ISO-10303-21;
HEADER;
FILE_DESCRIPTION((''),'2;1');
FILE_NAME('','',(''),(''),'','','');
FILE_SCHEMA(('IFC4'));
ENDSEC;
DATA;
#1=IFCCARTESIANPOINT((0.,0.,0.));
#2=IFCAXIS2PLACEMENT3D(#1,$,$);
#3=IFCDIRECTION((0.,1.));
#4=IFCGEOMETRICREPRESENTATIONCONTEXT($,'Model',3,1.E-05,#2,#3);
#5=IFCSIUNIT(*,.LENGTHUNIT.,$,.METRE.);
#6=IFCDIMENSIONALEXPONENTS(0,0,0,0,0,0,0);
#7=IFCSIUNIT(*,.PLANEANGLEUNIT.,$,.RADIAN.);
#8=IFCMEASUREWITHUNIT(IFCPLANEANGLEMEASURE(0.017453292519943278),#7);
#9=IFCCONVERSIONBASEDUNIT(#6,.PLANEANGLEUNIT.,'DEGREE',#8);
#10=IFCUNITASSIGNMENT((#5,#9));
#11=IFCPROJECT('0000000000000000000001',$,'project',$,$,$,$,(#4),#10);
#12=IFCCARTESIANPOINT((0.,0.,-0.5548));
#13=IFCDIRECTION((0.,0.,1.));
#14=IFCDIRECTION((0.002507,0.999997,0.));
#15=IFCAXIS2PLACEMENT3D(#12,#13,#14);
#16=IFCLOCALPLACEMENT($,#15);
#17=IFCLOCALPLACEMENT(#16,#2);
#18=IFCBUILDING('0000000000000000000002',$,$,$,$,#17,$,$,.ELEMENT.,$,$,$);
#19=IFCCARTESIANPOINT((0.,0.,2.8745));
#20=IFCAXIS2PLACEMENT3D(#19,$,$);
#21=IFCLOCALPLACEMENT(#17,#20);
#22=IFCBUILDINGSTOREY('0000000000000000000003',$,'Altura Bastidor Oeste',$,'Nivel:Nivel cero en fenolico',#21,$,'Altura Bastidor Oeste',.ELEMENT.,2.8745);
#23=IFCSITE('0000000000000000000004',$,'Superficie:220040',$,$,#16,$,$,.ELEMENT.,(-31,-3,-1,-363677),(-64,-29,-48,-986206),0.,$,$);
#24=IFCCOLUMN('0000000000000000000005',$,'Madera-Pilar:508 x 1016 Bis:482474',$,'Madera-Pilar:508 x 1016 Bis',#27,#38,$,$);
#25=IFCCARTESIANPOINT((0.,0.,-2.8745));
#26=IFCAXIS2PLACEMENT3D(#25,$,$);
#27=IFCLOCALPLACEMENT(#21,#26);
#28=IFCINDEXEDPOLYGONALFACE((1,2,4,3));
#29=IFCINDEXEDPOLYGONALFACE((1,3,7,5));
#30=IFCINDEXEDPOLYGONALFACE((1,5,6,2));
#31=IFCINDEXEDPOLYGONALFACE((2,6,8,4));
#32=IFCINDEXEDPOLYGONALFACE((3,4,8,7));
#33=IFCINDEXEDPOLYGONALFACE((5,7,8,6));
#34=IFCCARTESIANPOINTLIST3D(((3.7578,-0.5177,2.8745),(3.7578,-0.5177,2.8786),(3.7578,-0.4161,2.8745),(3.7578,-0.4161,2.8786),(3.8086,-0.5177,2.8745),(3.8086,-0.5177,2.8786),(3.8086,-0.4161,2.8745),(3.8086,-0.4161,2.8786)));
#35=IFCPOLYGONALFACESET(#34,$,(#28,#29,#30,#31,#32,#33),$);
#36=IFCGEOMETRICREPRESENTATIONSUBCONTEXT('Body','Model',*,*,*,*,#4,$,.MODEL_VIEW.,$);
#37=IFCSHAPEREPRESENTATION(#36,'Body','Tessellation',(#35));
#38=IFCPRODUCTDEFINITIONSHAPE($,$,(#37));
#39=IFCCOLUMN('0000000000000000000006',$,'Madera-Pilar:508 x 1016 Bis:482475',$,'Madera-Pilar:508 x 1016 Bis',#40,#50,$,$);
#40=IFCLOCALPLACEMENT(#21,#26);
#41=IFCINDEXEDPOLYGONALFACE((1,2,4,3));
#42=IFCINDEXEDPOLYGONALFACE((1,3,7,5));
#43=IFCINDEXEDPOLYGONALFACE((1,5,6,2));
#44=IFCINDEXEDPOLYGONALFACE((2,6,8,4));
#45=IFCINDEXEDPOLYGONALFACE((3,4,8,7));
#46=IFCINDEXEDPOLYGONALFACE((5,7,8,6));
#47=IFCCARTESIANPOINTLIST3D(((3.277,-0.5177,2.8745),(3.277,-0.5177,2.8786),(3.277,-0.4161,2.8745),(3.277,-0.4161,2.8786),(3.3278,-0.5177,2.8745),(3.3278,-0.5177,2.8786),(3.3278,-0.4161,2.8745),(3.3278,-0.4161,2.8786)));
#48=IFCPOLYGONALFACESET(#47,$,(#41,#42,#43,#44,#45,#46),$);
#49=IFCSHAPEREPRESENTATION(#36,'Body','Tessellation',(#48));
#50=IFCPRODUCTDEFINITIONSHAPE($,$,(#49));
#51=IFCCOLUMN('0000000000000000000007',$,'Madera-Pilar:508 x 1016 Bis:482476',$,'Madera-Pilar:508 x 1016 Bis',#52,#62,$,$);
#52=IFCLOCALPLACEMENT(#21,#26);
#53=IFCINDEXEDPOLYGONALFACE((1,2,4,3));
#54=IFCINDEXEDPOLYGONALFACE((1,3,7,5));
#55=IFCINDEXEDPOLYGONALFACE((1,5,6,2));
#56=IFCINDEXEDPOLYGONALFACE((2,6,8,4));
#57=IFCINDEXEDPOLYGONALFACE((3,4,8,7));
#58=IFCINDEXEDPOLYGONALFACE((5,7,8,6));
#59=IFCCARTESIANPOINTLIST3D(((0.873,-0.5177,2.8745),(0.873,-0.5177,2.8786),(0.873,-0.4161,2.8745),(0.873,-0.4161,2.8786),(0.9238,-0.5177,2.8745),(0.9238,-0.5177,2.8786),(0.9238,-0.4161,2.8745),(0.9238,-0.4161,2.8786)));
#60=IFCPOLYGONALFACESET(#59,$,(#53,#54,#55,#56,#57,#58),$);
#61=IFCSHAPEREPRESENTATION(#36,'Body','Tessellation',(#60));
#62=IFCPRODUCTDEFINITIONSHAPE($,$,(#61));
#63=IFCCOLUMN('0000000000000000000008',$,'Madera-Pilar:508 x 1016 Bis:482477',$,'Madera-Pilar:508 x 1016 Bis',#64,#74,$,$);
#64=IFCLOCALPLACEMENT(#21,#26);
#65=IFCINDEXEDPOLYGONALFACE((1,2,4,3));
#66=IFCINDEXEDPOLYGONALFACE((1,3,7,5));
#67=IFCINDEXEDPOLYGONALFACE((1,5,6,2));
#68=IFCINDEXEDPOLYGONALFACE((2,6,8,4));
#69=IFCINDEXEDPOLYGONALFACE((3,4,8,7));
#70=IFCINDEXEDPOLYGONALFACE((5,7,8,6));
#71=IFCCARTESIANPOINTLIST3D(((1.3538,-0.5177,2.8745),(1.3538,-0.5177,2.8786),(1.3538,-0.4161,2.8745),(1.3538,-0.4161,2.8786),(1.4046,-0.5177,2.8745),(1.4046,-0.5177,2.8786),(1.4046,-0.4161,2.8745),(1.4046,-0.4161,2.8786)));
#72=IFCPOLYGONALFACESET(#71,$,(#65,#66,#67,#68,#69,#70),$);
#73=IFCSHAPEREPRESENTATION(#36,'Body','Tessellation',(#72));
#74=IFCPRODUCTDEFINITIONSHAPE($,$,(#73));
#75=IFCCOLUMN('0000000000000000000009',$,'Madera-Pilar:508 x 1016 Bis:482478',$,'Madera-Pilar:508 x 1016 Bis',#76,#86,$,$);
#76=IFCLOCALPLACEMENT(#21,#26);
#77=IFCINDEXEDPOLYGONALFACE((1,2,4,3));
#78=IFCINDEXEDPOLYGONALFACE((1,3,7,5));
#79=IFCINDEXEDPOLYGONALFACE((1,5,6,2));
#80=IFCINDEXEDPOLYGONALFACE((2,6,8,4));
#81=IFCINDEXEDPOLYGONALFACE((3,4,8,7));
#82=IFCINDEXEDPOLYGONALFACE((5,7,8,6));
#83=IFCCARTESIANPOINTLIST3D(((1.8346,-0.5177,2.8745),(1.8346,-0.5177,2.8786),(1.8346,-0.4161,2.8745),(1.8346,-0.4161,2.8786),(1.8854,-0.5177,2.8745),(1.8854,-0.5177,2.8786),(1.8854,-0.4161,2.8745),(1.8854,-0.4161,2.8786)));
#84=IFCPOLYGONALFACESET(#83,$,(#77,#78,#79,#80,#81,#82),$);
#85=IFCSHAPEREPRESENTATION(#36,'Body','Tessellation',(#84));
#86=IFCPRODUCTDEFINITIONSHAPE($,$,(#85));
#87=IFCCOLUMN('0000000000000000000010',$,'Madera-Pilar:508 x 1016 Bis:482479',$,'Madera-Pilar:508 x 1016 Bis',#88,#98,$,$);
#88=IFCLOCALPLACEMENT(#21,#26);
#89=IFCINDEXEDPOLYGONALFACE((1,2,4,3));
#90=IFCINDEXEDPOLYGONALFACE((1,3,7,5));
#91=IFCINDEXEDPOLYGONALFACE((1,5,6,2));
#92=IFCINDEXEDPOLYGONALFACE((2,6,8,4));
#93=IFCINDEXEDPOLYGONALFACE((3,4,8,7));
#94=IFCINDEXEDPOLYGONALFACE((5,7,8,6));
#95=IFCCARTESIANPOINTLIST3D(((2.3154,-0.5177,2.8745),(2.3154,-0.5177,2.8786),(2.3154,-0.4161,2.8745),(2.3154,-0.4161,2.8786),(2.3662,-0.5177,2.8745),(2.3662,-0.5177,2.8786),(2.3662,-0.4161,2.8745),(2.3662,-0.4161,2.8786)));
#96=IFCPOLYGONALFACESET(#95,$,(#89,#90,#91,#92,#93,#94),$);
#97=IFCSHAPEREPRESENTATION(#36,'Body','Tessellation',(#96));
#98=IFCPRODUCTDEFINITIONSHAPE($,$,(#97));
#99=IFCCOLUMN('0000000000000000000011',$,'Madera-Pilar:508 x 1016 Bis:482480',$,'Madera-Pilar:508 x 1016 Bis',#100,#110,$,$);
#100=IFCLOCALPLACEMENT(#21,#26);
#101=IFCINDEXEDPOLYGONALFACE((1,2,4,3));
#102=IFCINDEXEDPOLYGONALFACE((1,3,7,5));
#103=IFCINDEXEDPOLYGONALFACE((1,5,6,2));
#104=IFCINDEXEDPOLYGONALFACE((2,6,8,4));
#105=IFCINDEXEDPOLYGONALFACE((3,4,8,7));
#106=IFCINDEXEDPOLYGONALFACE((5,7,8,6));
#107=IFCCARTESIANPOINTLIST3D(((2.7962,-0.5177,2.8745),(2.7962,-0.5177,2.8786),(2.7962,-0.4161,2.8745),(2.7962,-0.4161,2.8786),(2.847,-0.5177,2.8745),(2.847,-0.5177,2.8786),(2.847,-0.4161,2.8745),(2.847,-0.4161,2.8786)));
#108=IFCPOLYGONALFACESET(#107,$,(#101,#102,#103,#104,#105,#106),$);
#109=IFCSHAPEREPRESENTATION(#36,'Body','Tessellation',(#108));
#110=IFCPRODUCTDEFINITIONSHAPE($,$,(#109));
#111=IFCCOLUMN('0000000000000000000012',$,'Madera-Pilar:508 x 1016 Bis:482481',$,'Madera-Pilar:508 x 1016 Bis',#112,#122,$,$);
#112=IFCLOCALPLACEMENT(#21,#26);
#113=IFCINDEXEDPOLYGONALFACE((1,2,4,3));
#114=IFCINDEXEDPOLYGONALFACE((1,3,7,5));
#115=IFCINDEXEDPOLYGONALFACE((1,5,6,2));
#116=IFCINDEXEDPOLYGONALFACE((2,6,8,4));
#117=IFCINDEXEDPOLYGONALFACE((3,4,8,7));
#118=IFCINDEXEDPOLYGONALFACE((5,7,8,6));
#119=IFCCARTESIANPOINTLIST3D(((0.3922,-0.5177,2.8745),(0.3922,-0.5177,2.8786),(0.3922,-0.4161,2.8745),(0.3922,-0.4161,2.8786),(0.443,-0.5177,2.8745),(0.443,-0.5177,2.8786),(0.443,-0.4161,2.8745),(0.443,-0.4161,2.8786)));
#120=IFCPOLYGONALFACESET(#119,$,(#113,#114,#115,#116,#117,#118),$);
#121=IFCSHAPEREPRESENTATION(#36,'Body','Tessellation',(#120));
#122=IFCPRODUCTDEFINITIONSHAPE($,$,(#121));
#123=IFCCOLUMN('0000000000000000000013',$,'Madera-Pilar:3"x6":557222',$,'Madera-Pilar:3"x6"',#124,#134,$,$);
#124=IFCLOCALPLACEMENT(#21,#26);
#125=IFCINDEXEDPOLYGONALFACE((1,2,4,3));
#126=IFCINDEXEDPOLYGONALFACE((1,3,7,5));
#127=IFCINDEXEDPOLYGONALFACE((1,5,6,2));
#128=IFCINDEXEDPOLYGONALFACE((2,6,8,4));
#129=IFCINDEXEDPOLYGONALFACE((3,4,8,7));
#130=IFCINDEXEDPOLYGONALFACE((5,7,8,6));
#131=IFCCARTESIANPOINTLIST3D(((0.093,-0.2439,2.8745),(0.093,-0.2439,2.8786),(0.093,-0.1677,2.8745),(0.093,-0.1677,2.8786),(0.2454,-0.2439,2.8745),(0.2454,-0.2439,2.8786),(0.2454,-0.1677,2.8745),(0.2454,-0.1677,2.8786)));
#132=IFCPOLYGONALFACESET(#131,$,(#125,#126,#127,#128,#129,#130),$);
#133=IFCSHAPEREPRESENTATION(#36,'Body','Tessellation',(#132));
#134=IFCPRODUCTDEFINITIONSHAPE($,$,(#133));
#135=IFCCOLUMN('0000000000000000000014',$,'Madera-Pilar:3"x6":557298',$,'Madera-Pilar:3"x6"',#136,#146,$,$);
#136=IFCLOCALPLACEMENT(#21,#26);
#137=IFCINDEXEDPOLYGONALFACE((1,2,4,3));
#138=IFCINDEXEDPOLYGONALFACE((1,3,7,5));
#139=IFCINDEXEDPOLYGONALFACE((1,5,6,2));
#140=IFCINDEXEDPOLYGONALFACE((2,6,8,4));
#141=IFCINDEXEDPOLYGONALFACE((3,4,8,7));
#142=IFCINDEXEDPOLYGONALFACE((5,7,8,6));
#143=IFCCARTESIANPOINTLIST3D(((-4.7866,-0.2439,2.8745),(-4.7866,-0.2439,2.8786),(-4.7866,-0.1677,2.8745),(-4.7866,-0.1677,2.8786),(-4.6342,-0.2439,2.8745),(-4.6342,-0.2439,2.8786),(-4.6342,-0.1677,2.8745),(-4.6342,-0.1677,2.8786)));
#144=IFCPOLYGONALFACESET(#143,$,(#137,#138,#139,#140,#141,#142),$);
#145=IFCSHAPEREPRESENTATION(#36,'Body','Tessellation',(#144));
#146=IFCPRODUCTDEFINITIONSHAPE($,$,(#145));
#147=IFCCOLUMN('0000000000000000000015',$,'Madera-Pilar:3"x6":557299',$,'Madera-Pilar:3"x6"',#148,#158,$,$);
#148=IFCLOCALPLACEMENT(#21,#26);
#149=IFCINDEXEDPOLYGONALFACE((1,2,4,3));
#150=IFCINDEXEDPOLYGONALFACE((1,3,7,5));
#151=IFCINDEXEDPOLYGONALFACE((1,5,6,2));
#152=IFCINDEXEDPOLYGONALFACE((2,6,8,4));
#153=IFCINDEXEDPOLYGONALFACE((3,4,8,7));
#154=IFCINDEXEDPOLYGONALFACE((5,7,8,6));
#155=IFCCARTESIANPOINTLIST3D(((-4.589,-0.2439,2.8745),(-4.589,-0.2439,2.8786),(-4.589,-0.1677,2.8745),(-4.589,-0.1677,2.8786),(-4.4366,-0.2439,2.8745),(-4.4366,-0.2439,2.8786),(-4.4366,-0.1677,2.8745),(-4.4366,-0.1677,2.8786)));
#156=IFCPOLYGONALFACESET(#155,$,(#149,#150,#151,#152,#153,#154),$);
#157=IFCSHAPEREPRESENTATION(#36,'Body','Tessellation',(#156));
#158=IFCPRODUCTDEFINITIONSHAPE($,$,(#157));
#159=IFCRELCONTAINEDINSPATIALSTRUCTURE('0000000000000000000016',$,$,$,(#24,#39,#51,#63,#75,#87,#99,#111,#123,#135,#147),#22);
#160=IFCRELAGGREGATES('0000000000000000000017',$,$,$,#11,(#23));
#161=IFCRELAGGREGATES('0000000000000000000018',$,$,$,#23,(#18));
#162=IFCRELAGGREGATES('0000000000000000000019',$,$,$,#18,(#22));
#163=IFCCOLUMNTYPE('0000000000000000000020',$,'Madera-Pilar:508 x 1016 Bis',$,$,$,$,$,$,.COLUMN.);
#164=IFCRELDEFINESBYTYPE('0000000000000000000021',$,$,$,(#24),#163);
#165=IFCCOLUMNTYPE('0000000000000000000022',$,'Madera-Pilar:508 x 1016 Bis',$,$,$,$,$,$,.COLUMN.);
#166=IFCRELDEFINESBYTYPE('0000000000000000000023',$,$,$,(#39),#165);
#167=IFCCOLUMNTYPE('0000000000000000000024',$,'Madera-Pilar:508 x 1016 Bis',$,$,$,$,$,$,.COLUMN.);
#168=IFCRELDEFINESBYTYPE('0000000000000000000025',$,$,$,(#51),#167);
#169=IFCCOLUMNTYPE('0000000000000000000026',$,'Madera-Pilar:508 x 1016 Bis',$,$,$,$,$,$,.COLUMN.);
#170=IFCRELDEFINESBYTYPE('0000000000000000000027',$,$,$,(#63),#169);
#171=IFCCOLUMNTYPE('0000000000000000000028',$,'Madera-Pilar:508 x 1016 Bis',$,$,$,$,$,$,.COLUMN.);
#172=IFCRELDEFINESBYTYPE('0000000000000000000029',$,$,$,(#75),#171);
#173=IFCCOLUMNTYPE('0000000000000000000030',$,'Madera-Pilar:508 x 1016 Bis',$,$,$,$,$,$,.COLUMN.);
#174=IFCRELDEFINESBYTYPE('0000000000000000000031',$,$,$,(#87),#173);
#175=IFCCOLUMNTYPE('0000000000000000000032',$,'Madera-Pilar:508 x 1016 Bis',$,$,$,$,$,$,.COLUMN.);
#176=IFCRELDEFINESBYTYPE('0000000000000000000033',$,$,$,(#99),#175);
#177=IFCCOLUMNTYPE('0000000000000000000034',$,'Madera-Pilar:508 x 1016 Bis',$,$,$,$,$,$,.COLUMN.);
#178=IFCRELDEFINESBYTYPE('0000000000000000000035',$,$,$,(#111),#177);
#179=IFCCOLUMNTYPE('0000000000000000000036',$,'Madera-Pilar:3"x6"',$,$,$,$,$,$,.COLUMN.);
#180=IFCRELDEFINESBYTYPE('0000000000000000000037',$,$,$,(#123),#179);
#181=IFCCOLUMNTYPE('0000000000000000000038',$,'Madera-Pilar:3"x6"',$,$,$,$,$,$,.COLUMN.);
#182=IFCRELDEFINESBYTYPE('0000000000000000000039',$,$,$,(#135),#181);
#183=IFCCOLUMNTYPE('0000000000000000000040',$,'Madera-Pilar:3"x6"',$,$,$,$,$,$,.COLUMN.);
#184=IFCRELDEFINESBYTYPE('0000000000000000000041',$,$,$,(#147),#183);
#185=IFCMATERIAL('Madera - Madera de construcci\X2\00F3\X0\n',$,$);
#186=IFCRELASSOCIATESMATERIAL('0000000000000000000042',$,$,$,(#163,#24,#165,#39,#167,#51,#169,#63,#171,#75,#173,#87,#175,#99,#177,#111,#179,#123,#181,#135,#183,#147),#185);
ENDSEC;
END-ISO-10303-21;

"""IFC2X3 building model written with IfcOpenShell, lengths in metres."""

from ifc_helpers import new_model, entity, si_unit, converted_unit, direction, frame, frame_2d, origin, place, context, subcontext, project, spatial, rectangle, extrude, source, transform, mapped, material, type_object, type_shapes, element, save


model = new_model("IFC2X3")

# Units and contexts
model_context = context("Model", 3, precision=1e-05, world=origin(), true_north=direction((0.0, 1.0)))
body_context = subcontext(model_context, "Body", "Model", "MODEL_VIEW")
ifc_project = project(units=[si_unit("LENGTHUNIT", "METRE"), converted_unit("PLANEANGLEUNIT", "DEGREE", entity("IfcPlaneAngleMeasure", 0.017453292519943278), si_unit("PLANEANGLEUNIT", "RADIAN"), dimensions=[0, 0, 0, 0, 0, 0, 0])], contexts=[model_context])

# Site, building, storey
site_placement = place(None, frame((0.0, 0.0, -0.5548), z_axis=(0.0, 0.0, 1.0), x_axis=(0.002507, 0.999997, 0.0)))
site = spatial("IfcSite", under=ifc_project, at=site_placement, Name="Superficie:220040", CompositionType="ELEMENT", RefLatitude=(-31, -3, -1, -363677), RefLongitude=(-64, -29, -48, -986206), RefElevation=0.0)
building_placement = place(site_placement, origin())
building = spatial("IfcBuilding", under=site, at=building_placement, CompositionType="ELEMENT")
storey_placement = place(building_placement, frame((0.0, 0.0, 2.8745)))
storey = spatial("IfcBuildingStorey", under=building, at=storey_placement, Name="Altura Bastidor Oeste", ObjectType="Nivel:Nivel cero en fenolico", LongName="Altura Bastidor Oeste", CompositionType="ELEMENT", Elevation=2.8745)

# Columns
ifc_material_1 = material(Name="Madera - Madera de construcción")
column_type_1 = type_object("IfcColumnType", Name="Madera-Pilar:508 x 1016 Bis", PredefinedType="COLUMN", material=ifc_material_1)
shared_shape_1 = source(origin(), body_context, "Body", "SweptSolid", [
    extrude(rectangle(XDim=0.0508, YDim=0.1016, at=frame_2d((0.0, 0.0), x_axis=(1.0, 0.0))), frame((3.7832, -0.4669, 2.8745)), (0.0, 0.0, 1.0), 0.0041),
])
type_shapes(column_type_1, [shared_shape_1])
column_1_placement = place(storey_placement, frame((0.0, 0.0, -2.8745)))
element("IfcColumn", 1, at=column_1_placement, inside=storey, type_object=column_type_1, material=ifc_material_1, Name="Madera-Pilar:508 x 1016 Bis:482474", ObjectType="Madera-Pilar:508 x 1016 Bis", context=body_context, shape_type="MappedRepresentation", body=[
    mapped(shared_shape_1, transform((0.0, 0.0, 0.0), scale=1.0)),
])
column_type_2 = type_object("IfcColumnType", Name="Madera-Pilar:508 x 1016 Bis", PredefinedType="COLUMN", material=ifc_material_1)
shared_shape_2 = source(origin(), body_context, "Body", "SweptSolid", [
    extrude(rectangle(XDim=0.0508, YDim=0.1016, at=frame_2d((0.0, 0.0), x_axis=(1.0, 0.0))), frame((3.3024, -0.4669, 2.8745)), (0.0, 0.0, 1.0), 0.0041),
])
type_shapes(column_type_2, [shared_shape_2])
column_2_placement = place(storey_placement, frame((0.0, 0.0, -2.8745)))
element("IfcColumn", 2, at=column_2_placement, inside=storey, type_object=column_type_2, material=ifc_material_1, Name="Madera-Pilar:508 x 1016 Bis:482475", ObjectType="Madera-Pilar:508 x 1016 Bis", context=body_context, shape_type="MappedRepresentation", body=[
    mapped(shared_shape_2, transform((0.0, 0.0, 0.0), scale=1.0)),
])
column_type_3 = type_object("IfcColumnType", Name="Madera-Pilar:508 x 1016 Bis", PredefinedType="COLUMN", material=ifc_material_1)
shared_shape_3 = source(origin(), body_context, "Body", "SweptSolid", [
    extrude(rectangle(XDim=0.0508, YDim=0.1016, at=frame_2d((0.0, 0.0), x_axis=(1.0, 0.0))), frame((0.8984, -0.4669, 2.8745)), (0.0, 0.0, 1.0), 0.0041),
])
type_shapes(column_type_3, [shared_shape_3])
column_3_placement = place(storey_placement, frame((0.0, 0.0, -2.8745)))
element("IfcColumn", 3, at=column_3_placement, inside=storey, type_object=column_type_3, material=ifc_material_1, Name="Madera-Pilar:508 x 1016 Bis:482476", ObjectType="Madera-Pilar:508 x 1016 Bis", context=body_context, shape_type="MappedRepresentation", body=[
    mapped(shared_shape_3, transform((0.0, 0.0, 0.0), scale=1.0)),
])
column_type_4 = type_object("IfcColumnType", Name="Madera-Pilar:508 x 1016 Bis", PredefinedType="COLUMN", material=ifc_material_1)
shared_shape_4 = source(origin(), body_context, "Body", "SweptSolid", [
    extrude(rectangle(XDim=0.0508, YDim=0.1016, at=frame_2d((0.0, 0.0), x_axis=(1.0, 0.0))), frame((1.3792, -0.4669, 2.8745)), (0.0, 0.0, 1.0), 0.0041),
])
type_shapes(column_type_4, [shared_shape_4])
column_4_placement = place(storey_placement, frame((0.0, 0.0, -2.8745)))
element("IfcColumn", 4, at=column_4_placement, inside=storey, type_object=column_type_4, material=ifc_material_1, Name="Madera-Pilar:508 x 1016 Bis:482477", ObjectType="Madera-Pilar:508 x 1016 Bis", context=body_context, shape_type="MappedRepresentation", body=[
    mapped(shared_shape_4, transform((0.0, 0.0, 0.0), scale=1.0)),
])
column_type_5 = type_object("IfcColumnType", Name="Madera-Pilar:508 x 1016 Bis", PredefinedType="COLUMN", material=ifc_material_1)
shared_shape_5 = source(origin(), body_context, "Body", "SweptSolid", [
    extrude(rectangle(XDim=0.0508, YDim=0.1016, at=frame_2d((0.0, 0.0), x_axis=(1.0, 0.0))), frame((1.86, -0.4669, 2.8745)), (0.0, 0.0, 1.0), 0.0041),
])
type_shapes(column_type_5, [shared_shape_5])
column_5_placement = place(storey_placement, frame((0.0, 0.0, -2.8745)))
element("IfcColumn", 5, at=column_5_placement, inside=storey, type_object=column_type_5, material=ifc_material_1, Name="Madera-Pilar:508 x 1016 Bis:482478", ObjectType="Madera-Pilar:508 x 1016 Bis", context=body_context, shape_type="MappedRepresentation", body=[
    mapped(shared_shape_5, transform((0.0, 0.0, 0.0), scale=1.0)),
])
column_type_6 = type_object("IfcColumnType", Name="Madera-Pilar:508 x 1016 Bis", PredefinedType="COLUMN", material=ifc_material_1)
shared_shape_6 = source(origin(), body_context, "Body", "SweptSolid", [
    extrude(rectangle(XDim=0.0508, YDim=0.1016, at=frame_2d((0.0, 0.0), x_axis=(1.0, 0.0))), frame((2.3408, -0.4669, 2.8745)), (0.0, 0.0, 1.0), 0.0041),
])
type_shapes(column_type_6, [shared_shape_6])
column_6_placement = place(storey_placement, frame((0.0, 0.0, -2.8745)))
element("IfcColumn", 6, at=column_6_placement, inside=storey, type_object=column_type_6, material=ifc_material_1, Name="Madera-Pilar:508 x 1016 Bis:482479", ObjectType="Madera-Pilar:508 x 1016 Bis", context=body_context, shape_type="MappedRepresentation", body=[
    mapped(shared_shape_6, transform((0.0, 0.0, 0.0), scale=1.0)),
])
column_type_7 = type_object("IfcColumnType", Name="Madera-Pilar:508 x 1016 Bis", PredefinedType="COLUMN", material=ifc_material_1)
shared_shape_7 = source(origin(), body_context, "Body", "SweptSolid", [
    extrude(rectangle(XDim=0.0508, YDim=0.1016, at=frame_2d((0.0, 0.0), x_axis=(1.0, 0.0))), frame((2.8216, -0.4669, 2.8745)), (0.0, 0.0, 1.0), 0.0041),
])
type_shapes(column_type_7, [shared_shape_7])
column_7_placement = place(storey_placement, frame((0.0, 0.0, -2.8745)))
element("IfcColumn", 7, at=column_7_placement, inside=storey, type_object=column_type_7, material=ifc_material_1, Name="Madera-Pilar:508 x 1016 Bis:482480", ObjectType="Madera-Pilar:508 x 1016 Bis", context=body_context, shape_type="MappedRepresentation", body=[
    mapped(shared_shape_7, transform((0.0, 0.0, 0.0), scale=1.0)),
])
column_type_8 = type_object("IfcColumnType", Name="Madera-Pilar:508 x 1016 Bis", PredefinedType="COLUMN", material=ifc_material_1)
shared_shape_8 = source(origin(), body_context, "Body", "SweptSolid", [
    extrude(rectangle(XDim=0.0508, YDim=0.1016, at=frame_2d((0.0, 0.0), x_axis=(1.0, 0.0))), frame((0.4176, -0.4669, 2.8745)), (0.0, 0.0, 1.0), 0.0041),
])
type_shapes(column_type_8, [shared_shape_8])
column_8_placement = place(storey_placement, frame((0.0, 0.0, -2.8745)))
element("IfcColumn", 8, at=column_8_placement, inside=storey, type_object=column_type_8, material=ifc_material_1, Name="Madera-Pilar:508 x 1016 Bis:482481", ObjectType="Madera-Pilar:508 x 1016 Bis", context=body_context, shape_type="MappedRepresentation", body=[
    mapped(shared_shape_8, transform((0.0, 0.0, 0.0), scale=1.0)),
])
column_type_9 = type_object("IfcColumnType", Name="Madera-Pilar:3\"x6\"", PredefinedType="COLUMN", material=ifc_material_1)
shared_shape_9 = source(origin(), body_context, "Body", "SweptSolid", [
    extrude(rectangle(XDim=0.1524, YDim=0.0762, at=frame_2d((0.0, 0.0), x_axis=(1.0, 0.0))), frame((0.1692, -0.2058, 2.8745), z_axis=(0.0, 0.0, 1.0), x_axis=(-1.0, 0.0, 0.0)), (0.0, 0.0, 1.0), 0.0041),
])
type_shapes(column_type_9, [shared_shape_9])
column_9_placement = place(storey_placement, frame((0.0, 0.0, -2.8745)))
element("IfcColumn", 9, at=column_9_placement, inside=storey, type_object=column_type_9, material=ifc_material_1, Name="Madera-Pilar:3\"x6\":557222", ObjectType="Madera-Pilar:3\"x6\"", context=body_context, shape_type="MappedRepresentation", body=[
    mapped(shared_shape_9, transform((0.0, 0.0, 0.0), scale=1.0)),
])
column_type_10 = type_object("IfcColumnType", Name="Madera-Pilar:3\"x6\"", PredefinedType="COLUMN", material=ifc_material_1)
shared_shape_10 = source(origin(), body_context, "Body", "SweptSolid", [
    extrude(rectangle(XDim=0.1524, YDim=0.0762, at=frame_2d((0.0, 0.0), x_axis=(1.0, 0.0))), frame((-4.7104, -0.2058, 2.8745), z_axis=(0.0, 0.0, 1.0), x_axis=(-1.0, 0.0, 0.0)), (0.0, 0.0, 1.0), 0.0041),
])
type_shapes(column_type_10, [shared_shape_10])
column_10_placement = place(storey_placement, frame((0.0, 0.0, -2.8745)))
element("IfcColumn", 10, at=column_10_placement, inside=storey, type_object=column_type_10, material=ifc_material_1, Name="Madera-Pilar:3\"x6\":557298", ObjectType="Madera-Pilar:3\"x6\"", context=body_context, shape_type="MappedRepresentation", body=[
    mapped(shared_shape_10, transform((0.0, 0.0, 0.0), scale=1.0)),
])
column_type_11 = type_object("IfcColumnType", Name="Madera-Pilar:3\"x6\"", PredefinedType="COLUMN", material=ifc_material_1)
shared_shape_11 = source(origin(), body_context, "Body", "SweptSolid", [
    extrude(rectangle(XDim=0.1524, YDim=0.0762, at=frame_2d((0.0, 0.0), x_axis=(1.0, 0.0))), frame((-4.5128, -0.2058, 2.8745), z_axis=(0.0, 0.0, 1.0), x_axis=(-1.0, 0.0, 0.0)), (0.0, 0.0, 1.0), 0.0041),
])
type_shapes(column_type_11, [shared_shape_11])
column_11_placement = place(storey_placement, frame((0.0, 0.0, -2.8745)))
element("IfcColumn", 11, at=column_11_placement, inside=storey, type_object=column_type_11, material=ifc_material_1, Name="Madera-Pilar:3\"x6\":557299", ObjectType="Madera-Pilar:3\"x6\"", context=body_context, shape_type="MappedRepresentation", body=[
    mapped(shared_shape_11, transform((0.0, 0.0, 0.0), scale=1.0)),
])

save(model, "model.ifc")
